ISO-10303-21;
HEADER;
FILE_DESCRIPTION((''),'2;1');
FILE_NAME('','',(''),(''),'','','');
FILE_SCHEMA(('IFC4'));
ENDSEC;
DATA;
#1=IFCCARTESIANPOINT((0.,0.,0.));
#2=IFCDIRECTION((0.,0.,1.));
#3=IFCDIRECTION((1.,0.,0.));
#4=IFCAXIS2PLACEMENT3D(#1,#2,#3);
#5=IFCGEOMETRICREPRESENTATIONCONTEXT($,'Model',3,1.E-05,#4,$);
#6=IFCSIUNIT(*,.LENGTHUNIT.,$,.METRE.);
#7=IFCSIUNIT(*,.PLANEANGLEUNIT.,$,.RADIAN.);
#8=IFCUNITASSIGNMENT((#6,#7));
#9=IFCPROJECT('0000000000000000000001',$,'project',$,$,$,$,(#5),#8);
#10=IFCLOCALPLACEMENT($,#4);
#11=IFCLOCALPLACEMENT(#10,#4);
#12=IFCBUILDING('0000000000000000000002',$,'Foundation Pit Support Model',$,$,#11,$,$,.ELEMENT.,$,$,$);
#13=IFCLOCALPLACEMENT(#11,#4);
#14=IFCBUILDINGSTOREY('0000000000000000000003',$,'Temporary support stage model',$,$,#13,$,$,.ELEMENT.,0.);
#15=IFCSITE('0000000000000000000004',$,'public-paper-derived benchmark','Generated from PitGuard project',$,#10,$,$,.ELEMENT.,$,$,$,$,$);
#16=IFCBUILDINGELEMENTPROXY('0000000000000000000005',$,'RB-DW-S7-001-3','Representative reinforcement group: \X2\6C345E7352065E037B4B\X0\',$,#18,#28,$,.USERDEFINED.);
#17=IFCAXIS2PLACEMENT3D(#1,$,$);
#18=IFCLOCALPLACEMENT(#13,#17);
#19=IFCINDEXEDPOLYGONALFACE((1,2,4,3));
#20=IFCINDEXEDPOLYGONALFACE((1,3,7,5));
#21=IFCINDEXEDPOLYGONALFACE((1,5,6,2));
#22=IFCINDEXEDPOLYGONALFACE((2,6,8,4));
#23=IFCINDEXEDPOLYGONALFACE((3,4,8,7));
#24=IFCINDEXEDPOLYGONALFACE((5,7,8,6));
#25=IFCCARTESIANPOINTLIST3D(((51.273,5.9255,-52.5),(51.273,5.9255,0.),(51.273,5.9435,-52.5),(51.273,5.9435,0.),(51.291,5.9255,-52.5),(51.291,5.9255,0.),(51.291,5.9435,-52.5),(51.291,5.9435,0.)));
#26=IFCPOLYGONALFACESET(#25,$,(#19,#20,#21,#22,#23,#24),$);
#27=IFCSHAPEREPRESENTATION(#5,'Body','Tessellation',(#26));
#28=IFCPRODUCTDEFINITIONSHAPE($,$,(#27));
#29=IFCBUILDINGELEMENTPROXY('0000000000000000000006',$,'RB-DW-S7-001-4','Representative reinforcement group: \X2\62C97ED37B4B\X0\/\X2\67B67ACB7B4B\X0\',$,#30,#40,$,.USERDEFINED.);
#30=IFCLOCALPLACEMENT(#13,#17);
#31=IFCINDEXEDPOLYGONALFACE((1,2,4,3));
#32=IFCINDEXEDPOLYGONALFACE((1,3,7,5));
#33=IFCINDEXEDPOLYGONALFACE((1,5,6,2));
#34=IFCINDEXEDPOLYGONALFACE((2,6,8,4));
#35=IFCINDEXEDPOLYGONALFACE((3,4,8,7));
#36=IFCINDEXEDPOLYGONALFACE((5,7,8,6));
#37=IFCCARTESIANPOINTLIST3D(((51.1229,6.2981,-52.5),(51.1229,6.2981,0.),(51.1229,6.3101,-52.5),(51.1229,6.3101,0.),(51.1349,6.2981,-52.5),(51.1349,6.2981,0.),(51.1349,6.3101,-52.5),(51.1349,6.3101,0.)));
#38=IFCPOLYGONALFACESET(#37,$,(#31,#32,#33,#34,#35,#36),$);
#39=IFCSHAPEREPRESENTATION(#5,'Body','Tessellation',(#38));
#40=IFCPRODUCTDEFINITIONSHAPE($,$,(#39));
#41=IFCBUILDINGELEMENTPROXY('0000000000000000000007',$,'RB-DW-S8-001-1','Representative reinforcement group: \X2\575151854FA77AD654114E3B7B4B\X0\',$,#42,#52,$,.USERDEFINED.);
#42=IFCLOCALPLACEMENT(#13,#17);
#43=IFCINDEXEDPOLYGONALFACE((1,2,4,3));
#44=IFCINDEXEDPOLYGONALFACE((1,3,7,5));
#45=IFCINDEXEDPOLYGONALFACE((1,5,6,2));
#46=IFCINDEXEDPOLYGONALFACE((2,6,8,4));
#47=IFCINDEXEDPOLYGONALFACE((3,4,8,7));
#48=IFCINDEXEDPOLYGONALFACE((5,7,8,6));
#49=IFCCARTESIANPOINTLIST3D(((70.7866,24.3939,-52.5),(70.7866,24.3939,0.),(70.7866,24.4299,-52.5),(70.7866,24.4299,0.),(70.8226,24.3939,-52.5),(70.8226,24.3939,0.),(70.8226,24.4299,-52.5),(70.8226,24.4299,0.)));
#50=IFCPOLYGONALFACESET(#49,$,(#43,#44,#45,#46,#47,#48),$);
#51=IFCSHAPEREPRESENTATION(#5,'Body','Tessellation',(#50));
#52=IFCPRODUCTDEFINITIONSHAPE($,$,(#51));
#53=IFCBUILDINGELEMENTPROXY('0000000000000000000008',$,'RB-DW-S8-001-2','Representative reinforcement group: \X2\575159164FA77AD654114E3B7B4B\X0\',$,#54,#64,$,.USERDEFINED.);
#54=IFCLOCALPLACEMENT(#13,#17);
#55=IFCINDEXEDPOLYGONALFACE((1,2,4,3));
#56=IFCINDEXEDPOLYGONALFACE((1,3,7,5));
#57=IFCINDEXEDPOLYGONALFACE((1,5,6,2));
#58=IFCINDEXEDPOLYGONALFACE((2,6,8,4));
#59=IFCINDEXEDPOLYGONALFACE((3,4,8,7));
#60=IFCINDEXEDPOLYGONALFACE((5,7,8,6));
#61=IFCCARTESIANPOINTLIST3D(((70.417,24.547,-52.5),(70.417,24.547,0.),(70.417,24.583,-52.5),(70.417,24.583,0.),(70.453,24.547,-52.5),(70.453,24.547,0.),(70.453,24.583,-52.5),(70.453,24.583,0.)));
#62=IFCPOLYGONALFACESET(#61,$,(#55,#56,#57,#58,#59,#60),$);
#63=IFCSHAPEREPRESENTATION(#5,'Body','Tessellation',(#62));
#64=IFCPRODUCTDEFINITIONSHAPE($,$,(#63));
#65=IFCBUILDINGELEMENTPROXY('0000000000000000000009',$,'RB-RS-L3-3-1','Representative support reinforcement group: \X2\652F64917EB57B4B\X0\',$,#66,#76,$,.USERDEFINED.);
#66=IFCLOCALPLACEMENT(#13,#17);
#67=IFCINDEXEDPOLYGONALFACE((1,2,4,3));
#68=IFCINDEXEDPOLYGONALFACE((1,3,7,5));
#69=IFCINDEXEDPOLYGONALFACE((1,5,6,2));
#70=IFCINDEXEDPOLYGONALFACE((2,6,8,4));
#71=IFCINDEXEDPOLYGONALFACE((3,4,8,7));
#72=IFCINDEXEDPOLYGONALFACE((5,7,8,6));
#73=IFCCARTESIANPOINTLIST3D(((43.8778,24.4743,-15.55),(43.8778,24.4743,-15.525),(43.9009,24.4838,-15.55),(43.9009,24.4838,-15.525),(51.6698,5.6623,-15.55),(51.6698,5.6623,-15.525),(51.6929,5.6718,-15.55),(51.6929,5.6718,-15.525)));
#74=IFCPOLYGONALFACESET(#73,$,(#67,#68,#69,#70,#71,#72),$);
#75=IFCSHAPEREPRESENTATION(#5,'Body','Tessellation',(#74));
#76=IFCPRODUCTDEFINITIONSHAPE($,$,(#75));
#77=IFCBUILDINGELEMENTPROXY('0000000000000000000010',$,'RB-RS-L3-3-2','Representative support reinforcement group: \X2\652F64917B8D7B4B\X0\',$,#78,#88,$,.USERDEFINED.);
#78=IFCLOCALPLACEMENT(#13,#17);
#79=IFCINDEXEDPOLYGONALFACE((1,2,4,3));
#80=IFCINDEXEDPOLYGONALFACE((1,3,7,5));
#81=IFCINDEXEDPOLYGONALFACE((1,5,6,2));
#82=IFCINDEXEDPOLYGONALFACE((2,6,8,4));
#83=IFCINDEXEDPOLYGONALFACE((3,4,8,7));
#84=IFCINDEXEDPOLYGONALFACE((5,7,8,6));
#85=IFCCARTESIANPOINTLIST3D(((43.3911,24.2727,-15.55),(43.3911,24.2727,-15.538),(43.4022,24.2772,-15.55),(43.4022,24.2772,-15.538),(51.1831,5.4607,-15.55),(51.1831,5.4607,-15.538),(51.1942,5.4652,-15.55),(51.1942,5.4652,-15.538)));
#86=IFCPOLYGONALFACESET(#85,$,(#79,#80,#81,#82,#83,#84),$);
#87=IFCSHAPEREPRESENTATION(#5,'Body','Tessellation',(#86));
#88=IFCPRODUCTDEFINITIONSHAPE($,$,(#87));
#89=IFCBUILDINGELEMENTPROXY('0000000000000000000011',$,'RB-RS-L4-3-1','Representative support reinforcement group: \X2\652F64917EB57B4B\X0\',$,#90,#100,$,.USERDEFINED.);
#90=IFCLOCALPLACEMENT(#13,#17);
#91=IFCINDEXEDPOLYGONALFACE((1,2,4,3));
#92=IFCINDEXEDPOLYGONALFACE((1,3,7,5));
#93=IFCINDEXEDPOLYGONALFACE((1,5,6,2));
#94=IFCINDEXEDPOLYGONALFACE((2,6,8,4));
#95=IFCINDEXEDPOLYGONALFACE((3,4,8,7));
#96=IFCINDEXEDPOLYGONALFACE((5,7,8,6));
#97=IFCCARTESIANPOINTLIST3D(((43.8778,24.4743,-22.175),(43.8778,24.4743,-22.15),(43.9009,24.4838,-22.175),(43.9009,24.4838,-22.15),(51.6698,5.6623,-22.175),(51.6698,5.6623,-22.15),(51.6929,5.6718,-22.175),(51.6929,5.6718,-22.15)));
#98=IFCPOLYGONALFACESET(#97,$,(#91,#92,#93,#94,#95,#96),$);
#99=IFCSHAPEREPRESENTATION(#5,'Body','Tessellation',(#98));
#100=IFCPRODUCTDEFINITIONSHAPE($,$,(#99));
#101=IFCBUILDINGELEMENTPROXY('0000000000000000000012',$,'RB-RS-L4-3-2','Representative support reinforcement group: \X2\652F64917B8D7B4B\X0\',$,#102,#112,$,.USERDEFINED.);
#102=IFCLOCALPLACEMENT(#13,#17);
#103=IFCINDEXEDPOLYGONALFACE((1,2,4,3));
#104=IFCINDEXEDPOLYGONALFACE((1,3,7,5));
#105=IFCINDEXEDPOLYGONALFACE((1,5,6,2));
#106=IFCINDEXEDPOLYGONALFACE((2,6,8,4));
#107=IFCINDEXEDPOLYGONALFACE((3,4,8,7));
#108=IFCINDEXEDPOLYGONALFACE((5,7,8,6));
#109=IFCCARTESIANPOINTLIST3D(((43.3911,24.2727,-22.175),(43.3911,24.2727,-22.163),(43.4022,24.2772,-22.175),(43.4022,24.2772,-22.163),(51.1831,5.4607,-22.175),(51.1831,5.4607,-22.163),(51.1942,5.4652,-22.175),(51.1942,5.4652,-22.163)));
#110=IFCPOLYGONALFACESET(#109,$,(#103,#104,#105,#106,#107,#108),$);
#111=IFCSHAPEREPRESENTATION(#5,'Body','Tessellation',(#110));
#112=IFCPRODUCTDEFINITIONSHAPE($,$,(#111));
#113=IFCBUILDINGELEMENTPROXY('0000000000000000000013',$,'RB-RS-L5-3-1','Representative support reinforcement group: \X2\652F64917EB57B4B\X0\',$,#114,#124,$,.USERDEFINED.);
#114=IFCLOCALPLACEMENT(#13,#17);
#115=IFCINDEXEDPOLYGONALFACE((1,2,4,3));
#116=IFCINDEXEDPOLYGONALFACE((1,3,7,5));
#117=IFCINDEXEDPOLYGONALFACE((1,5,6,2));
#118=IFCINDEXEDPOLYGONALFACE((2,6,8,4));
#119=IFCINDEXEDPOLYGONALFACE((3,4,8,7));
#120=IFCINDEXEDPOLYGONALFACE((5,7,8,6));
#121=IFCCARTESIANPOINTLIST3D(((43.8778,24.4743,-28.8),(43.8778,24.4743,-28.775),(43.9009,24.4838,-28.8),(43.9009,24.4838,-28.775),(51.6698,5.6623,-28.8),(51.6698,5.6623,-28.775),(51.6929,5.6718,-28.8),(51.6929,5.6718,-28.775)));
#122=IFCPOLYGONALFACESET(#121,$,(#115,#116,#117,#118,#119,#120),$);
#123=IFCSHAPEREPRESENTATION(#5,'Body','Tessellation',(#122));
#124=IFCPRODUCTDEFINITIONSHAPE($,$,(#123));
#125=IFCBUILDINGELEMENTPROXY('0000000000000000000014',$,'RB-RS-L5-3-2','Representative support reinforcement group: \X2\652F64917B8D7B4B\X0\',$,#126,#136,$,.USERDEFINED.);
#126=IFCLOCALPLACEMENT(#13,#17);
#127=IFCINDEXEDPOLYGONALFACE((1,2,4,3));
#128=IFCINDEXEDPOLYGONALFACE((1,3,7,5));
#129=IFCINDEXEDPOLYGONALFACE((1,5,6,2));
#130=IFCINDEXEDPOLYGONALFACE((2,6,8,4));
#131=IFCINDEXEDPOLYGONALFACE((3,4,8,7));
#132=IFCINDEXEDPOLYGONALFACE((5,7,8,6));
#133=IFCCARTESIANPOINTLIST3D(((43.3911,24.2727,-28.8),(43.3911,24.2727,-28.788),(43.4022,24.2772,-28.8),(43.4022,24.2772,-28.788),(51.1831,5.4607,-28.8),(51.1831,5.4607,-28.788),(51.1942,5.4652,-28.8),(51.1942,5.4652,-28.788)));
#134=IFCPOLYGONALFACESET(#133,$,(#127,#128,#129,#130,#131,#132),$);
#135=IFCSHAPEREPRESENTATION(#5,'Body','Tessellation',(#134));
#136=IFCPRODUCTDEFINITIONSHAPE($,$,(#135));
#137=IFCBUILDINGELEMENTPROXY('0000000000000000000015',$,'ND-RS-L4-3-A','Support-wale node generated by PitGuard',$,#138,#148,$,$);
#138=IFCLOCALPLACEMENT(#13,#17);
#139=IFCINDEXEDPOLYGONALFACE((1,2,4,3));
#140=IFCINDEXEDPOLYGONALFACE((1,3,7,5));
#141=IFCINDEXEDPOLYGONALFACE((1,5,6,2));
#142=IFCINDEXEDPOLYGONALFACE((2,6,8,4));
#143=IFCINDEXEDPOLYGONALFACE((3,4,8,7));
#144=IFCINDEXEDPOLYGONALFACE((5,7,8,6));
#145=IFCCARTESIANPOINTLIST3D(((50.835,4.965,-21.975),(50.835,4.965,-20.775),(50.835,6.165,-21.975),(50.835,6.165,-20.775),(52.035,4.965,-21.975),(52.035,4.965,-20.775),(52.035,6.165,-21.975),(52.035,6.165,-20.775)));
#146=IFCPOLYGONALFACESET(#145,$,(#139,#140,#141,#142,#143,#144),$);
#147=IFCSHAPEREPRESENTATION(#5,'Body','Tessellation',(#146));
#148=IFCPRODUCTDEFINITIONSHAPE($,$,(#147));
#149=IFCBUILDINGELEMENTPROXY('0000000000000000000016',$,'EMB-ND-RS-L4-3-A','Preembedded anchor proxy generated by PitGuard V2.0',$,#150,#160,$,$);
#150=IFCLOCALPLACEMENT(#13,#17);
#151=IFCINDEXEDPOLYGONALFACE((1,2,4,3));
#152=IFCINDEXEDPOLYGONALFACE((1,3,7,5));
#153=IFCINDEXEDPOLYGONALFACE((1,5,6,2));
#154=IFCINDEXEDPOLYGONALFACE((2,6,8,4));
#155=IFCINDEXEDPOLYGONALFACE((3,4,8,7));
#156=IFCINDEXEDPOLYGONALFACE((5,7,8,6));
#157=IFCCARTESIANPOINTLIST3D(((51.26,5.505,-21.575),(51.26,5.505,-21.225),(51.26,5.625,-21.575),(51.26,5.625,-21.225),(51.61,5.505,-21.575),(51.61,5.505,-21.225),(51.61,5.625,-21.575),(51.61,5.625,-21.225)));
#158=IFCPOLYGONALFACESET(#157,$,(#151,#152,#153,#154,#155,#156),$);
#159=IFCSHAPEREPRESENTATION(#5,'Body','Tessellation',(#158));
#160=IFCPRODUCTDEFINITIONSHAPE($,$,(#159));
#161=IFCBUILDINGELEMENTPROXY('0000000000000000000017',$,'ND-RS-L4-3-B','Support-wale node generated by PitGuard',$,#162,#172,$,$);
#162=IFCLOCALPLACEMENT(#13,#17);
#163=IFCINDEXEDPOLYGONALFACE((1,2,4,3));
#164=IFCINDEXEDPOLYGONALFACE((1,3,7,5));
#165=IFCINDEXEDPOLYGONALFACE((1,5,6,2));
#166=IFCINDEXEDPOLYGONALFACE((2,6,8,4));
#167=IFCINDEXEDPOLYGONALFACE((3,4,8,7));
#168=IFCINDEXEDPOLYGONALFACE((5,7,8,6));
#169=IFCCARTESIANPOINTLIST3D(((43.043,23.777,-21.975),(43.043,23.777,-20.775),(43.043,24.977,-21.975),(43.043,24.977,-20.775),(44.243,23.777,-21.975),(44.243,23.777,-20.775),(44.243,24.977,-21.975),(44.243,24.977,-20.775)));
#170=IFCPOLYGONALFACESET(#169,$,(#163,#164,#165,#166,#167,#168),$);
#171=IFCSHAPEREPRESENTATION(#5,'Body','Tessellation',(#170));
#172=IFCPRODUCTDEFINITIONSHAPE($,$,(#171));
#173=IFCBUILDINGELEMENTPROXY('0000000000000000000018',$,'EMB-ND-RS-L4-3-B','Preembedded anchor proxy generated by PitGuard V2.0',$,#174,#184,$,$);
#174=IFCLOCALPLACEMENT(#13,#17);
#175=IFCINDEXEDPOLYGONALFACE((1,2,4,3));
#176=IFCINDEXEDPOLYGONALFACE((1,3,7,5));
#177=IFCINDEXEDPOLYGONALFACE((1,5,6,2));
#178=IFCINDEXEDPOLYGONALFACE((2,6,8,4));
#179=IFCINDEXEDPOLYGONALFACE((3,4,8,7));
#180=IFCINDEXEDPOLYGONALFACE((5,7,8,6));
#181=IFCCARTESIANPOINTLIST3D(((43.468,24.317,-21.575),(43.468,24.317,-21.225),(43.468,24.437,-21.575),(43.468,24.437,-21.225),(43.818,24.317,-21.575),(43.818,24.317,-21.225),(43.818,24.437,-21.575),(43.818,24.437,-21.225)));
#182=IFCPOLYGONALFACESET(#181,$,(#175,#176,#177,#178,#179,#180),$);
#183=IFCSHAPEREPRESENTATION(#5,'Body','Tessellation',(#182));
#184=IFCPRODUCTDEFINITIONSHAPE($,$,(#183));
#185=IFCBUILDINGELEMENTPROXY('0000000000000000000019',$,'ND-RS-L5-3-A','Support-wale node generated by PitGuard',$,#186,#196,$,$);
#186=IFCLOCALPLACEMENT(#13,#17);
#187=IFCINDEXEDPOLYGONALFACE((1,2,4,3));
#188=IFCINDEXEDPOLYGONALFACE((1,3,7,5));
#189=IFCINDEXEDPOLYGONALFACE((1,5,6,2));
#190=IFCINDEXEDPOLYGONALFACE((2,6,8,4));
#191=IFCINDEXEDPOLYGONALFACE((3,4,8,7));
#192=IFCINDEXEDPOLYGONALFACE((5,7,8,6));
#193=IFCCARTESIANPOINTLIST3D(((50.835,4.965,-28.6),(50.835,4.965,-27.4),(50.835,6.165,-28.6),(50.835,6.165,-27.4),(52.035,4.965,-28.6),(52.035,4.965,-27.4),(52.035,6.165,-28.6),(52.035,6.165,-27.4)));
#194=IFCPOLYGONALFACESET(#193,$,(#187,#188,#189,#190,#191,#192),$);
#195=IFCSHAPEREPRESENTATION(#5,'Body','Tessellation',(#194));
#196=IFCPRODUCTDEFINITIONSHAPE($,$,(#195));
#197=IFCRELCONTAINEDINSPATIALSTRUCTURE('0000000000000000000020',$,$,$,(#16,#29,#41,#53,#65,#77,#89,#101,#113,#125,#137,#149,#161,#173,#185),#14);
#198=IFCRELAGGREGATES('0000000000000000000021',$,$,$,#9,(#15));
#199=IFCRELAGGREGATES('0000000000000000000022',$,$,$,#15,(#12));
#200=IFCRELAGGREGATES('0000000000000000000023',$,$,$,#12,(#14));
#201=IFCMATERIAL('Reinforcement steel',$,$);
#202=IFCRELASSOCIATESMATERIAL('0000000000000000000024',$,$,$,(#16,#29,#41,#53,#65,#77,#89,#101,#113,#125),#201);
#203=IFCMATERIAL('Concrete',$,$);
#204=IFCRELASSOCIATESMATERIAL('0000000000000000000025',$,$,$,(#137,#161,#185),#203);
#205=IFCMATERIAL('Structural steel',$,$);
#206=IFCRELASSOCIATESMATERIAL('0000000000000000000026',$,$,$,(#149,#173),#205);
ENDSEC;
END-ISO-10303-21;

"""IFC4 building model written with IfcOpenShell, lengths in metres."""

from ifc_helpers import new_model, si_unit, frame, origin_with_axes, origin_2d, place, context, project, spatial, rectangle, extrude, material, element, save


model = new_model("IFC4")

# Units and contexts
model_context = context("Model", 3, precision=1e-05, world=origin_with_axes())
ifc_project = project(units=[si_unit("LENGTHUNIT", "METRE"), si_unit("PLANEANGLEUNIT", "RADIAN")], contexts=[model_context])

# Site, building, storey
site_placement = place(None, origin_with_axes())
site = spatial("IfcSite", under=ifc_project, at=site_placement, Name="public-paper-derived benchmark", Description="Generated from PitGuard project", CompositionType="ELEMENT")
building_placement = place(site_placement, origin_with_axes())
building = spatial("IfcBuilding", under=site, at=building_placement, Name="Foundation Pit Support Model", CompositionType="ELEMENT")
storey_placement = place(building_placement, origin_with_axes())
storey = spatial("IfcBuildingStorey", under=building, at=storey_placement, Name="Temporary support stage model", CompositionType="ELEMENT", Elevation=0.0)

# Shared definitions
ifc_material_1 = material(Name="Structural steel")

# Shared definitions
ifc_material_2 = material(Name="Concrete")

# Building element proxies
ifc_material_3 = material(Name="Reinforcement steel")
proxy_1_placement = place(storey_placement, frame((51.282, 5.9345, -52.5), z_axis=(0.0, 0.0, 1.0), x_axis=(1.0, 0.0, 0.0)))
element("IfcBuildingElementProxy", 1, at=proxy_1_placement, inside=storey, material=ifc_material_3, Name="RB-DW-S7-001-3", Description="Representative reinforcement group: 水平分布筋", PredefinedType="USERDEFINED", context=model_context, shape_type="SweptSolid", body=[
    extrude(rectangle(XDim=0.018, YDim=0.018, at=origin_2d()), origin_with_axes(), (0.0, 0.0, 1.0), 52.5),
])
proxy_2_placement = place(storey_placement, frame((51.1289, 6.3041, -52.5), z_axis=(0.0, 0.0, 1.0), x_axis=(1.0, 0.0, 0.0)))
element("IfcBuildingElementProxy", 2, at=proxy_2_placement, inside=storey, material=ifc_material_3, Name="RB-DW-S7-001-4", Description="Representative reinforcement group: 拉结筋/架立筋", PredefinedType="USERDEFINED", context=model_context, shape_type="SweptSolid", body=[
    extrude(rectangle(XDim=0.012, YDim=0.012, at=origin_2d()), origin_with_axes(), (0.0, 0.0, 1.0), 52.5),
])
for number, where, z_axis, x_axis, name, description in (
    (3, (70.8046, 24.4119, -52.5), (0.0, 0.0, 1.0), (1.0, 0.0, 0.0), "RB-DW-S8-001-1", "Representative reinforcement group: 坑内侧竖向主筋"),
    (4, (70.435, 24.565, -52.5), (0.0, 0.0, 1.0), (1.0, 0.0, 0.0), "RB-DW-S8-001-2", "Representative reinforcement group: 坑外侧竖向主筋"),
):
    element("IfcBuildingElementProxy", number, at=place(storey_placement, frame(where, z_axis=z_axis, x_axis=x_axis)), inside=storey, material=ifc_material_3, Name=name, Description=description, PredefinedType="USERDEFINED", context=model_context, shape_type="SweptSolid", body=[
        extrude(rectangle(XDim=0.036, YDim=0.036, at=origin_2d()), origin_with_axes(), (0.0, 0.0, 1.0), 52.5),
    ])
proxy_3_placement = place(storey_placement, frame((47.7854, 15.073, -15.55), z_axis=(0.0, 0.0, 1.0), x_axis=(-0.382676, 0.923883, 0.0)))
element("IfcBuildingElementProxy", 5, at=proxy_3_placement, inside=storey, material=ifc_material_3, Name="RB-RS-L3-3-1", Description="Representative support reinforcement group: 支撑纵筋", PredefinedType="USERDEFINED", context=model_context, shape_type="SweptSolid", body=[
    extrude(rectangle(XDim=20.3619, YDim=0.025, at=origin_2d()), origin_with_axes(), (0.0, 0.0, 1.0), 0.025),
])
proxy_4_placement = place(storey_placement, frame((47.2926, 14.869, -15.55), z_axis=(0.0, 0.0, 1.0), x_axis=(-0.382676, 0.923883, 0.0)))
element("IfcBuildingElementProxy", 6, at=proxy_4_placement, inside=storey, material=ifc_material_3, Name="RB-RS-L3-3-2", Description="Representative support reinforcement group: 支撑箍筋", PredefinedType="USERDEFINED", context=model_context, shape_type="SweptSolid", body=[
    extrude(rectangle(XDim=20.3619, YDim=0.012, at=origin_2d()), origin_with_axes(), (0.0, 0.0, 1.0), 0.012),
])
proxy_5_placement = place(storey_placement, frame((47.7854, 15.073, -22.175), z_axis=(0.0, 0.0, 1.0), x_axis=(-0.382676, 0.923883, 0.0)))
element("IfcBuildingElementProxy", 7, at=proxy_5_placement, inside=storey, material=ifc_material_3, Name="RB-RS-L4-3-1", Description="Representative support reinforcement group: 支撑纵筋", PredefinedType="USERDEFINED", context=model_context, shape_type="SweptSolid", body=[
    extrude(rectangle(XDim=20.3619, YDim=0.025, at=origin_2d()), origin_with_axes(), (0.0, 0.0, 1.0), 0.025),
])
proxy_6_placement = place(storey_placement, frame((47.2926, 14.869, -22.175), z_axis=(0.0, 0.0, 1.0), x_axis=(-0.382676, 0.923883, 0.0)))
element("IfcBuildingElementProxy", 8, at=proxy_6_placement, inside=storey, material=ifc_material_3, Name="RB-RS-L4-3-2", Description="Representative support reinforcement group: 支撑箍筋", PredefinedType="USERDEFINED", context=model_context, shape_type="SweptSolid", body=[
    extrude(rectangle(XDim=20.3619, YDim=0.012, at=origin_2d()), origin_with_axes(), (0.0, 0.0, 1.0), 0.012),
])
proxy_7_placement = place(storey_placement, frame((47.7854, 15.073, -28.8), z_axis=(0.0, 0.0, 1.0), x_axis=(-0.382676, 0.923883, 0.0)))
element("IfcBuildingElementProxy", 9, at=proxy_7_placement, inside=storey, material=ifc_material_3, Name="RB-RS-L5-3-1", Description="Representative support reinforcement group: 支撑纵筋", PredefinedType="USERDEFINED", context=model_context, shape_type="SweptSolid", body=[
    extrude(rectangle(XDim=20.3619, YDim=0.025, at=origin_2d()), origin_with_axes(), (0.0, 0.0, 1.0), 0.025),
])
proxy_8_placement = place(storey_placement, frame((47.2926, 14.869, -28.8), z_axis=(0.0, 0.0, 1.0), x_axis=(-0.382676, 0.923883, 0.0)))
element("IfcBuildingElementProxy", 10, at=proxy_8_placement, inside=storey, material=ifc_material_3, Name="RB-RS-L5-3-2", Description="Representative support reinforcement group: 支撑箍筋", PredefinedType="USERDEFINED", context=model_context, shape_type="SweptSolid", body=[
    extrude(rectangle(XDim=20.3619, YDim=0.012, at=origin_2d()), origin_with_axes(), (0.0, 0.0, 1.0), 0.012),
])
proxy_9_placement = place(storey_placement, frame((51.435, 5.565, -21.975), z_axis=(0.0, 0.0, 1.0), x_axis=(1.0, 0.0, 0.0)))
element("IfcBuildingElementProxy", 11, at=proxy_9_placement, inside=storey, material=ifc_material_2, Name="ND-RS-L4-3-A", Description="Support-wale node generated by PitGuard", context=model_context, shape_type="SweptSolid", body=[
    extrude(rectangle(XDim=1.2, YDim=1.2, at=origin_2d()), origin_with_axes(), (0.0, 0.0, 1.0), 1.2),
])
proxy_10_placement = place(storey_placement, frame((51.435, 5.565, -21.575), z_axis=(0.0, 0.0, 1.0), x_axis=(1.0, 0.0, 0.0)))
element("IfcBuildingElementProxy", 12, at=proxy_10_placement, inside=storey, material=ifc_material_1, Name="EMB-ND-RS-L4-3-A", Description="Preembedded anchor proxy generated by PitGuard V2.0", context=model_context, shape_type="SweptSolid", body=[
    extrude(rectangle(XDim=0.35, YDim=0.12, at=origin_2d()), origin_with_axes(), (0.0, 0.0, 1.0), 0.35),
])
proxy_11_placement = place(storey_placement, frame((43.643, 24.377, -21.975), z_axis=(0.0, 0.0, 1.0), x_axis=(1.0, 0.0, 0.0)))
element("IfcBuildingElementProxy", 13, at=proxy_11_placement, inside=storey, material=ifc_material_2, Name="ND-RS-L4-3-B", Description="Support-wale node generated by PitGuard", context=model_context, shape_type="SweptSolid", body=[
    extrude(rectangle(XDim=1.2, YDim=1.2, at=origin_2d()), origin_with_axes(), (0.0, 0.0, 1.0), 1.2),
])
proxy_12_placement = place(storey_placement, frame((43.643, 24.377, -21.575), z_axis=(0.0, 0.0, 1.0), x_axis=(1.0, 0.0, 0.0)))
element("IfcBuildingElementProxy", 14, at=proxy_12_placement, inside=storey, material=ifc_material_1, Name="EMB-ND-RS-L4-3-B", Description="Preembedded anchor proxy generated by PitGuard V2.0", context=model_context, shape_type="SweptSolid", body=[
    extrude(rectangle(XDim=0.35, YDim=0.12, at=origin_2d()), origin_with_axes(), (0.0, 0.0, 1.0), 0.35),
])
proxy_13_placement = place(storey_placement, frame((51.435, 5.565, -28.6), z_axis=(0.0, 0.0, 1.0), x_axis=(1.0, 0.0, 0.0)))
element("IfcBuildingElementProxy", 15, at=proxy_13_placement, inside=storey, material=ifc_material_2, Name="ND-RS-L5-3-A", Description="Support-wale node generated by PitGuard", context=model_context, shape_type="SweptSolid", body=[
    extrude(rectangle(XDim=1.2, YDim=1.2, at=origin_2d()), origin_with_axes(), (0.0, 0.0, 1.0), 1.2),
])

save(model, "model.ifc")
